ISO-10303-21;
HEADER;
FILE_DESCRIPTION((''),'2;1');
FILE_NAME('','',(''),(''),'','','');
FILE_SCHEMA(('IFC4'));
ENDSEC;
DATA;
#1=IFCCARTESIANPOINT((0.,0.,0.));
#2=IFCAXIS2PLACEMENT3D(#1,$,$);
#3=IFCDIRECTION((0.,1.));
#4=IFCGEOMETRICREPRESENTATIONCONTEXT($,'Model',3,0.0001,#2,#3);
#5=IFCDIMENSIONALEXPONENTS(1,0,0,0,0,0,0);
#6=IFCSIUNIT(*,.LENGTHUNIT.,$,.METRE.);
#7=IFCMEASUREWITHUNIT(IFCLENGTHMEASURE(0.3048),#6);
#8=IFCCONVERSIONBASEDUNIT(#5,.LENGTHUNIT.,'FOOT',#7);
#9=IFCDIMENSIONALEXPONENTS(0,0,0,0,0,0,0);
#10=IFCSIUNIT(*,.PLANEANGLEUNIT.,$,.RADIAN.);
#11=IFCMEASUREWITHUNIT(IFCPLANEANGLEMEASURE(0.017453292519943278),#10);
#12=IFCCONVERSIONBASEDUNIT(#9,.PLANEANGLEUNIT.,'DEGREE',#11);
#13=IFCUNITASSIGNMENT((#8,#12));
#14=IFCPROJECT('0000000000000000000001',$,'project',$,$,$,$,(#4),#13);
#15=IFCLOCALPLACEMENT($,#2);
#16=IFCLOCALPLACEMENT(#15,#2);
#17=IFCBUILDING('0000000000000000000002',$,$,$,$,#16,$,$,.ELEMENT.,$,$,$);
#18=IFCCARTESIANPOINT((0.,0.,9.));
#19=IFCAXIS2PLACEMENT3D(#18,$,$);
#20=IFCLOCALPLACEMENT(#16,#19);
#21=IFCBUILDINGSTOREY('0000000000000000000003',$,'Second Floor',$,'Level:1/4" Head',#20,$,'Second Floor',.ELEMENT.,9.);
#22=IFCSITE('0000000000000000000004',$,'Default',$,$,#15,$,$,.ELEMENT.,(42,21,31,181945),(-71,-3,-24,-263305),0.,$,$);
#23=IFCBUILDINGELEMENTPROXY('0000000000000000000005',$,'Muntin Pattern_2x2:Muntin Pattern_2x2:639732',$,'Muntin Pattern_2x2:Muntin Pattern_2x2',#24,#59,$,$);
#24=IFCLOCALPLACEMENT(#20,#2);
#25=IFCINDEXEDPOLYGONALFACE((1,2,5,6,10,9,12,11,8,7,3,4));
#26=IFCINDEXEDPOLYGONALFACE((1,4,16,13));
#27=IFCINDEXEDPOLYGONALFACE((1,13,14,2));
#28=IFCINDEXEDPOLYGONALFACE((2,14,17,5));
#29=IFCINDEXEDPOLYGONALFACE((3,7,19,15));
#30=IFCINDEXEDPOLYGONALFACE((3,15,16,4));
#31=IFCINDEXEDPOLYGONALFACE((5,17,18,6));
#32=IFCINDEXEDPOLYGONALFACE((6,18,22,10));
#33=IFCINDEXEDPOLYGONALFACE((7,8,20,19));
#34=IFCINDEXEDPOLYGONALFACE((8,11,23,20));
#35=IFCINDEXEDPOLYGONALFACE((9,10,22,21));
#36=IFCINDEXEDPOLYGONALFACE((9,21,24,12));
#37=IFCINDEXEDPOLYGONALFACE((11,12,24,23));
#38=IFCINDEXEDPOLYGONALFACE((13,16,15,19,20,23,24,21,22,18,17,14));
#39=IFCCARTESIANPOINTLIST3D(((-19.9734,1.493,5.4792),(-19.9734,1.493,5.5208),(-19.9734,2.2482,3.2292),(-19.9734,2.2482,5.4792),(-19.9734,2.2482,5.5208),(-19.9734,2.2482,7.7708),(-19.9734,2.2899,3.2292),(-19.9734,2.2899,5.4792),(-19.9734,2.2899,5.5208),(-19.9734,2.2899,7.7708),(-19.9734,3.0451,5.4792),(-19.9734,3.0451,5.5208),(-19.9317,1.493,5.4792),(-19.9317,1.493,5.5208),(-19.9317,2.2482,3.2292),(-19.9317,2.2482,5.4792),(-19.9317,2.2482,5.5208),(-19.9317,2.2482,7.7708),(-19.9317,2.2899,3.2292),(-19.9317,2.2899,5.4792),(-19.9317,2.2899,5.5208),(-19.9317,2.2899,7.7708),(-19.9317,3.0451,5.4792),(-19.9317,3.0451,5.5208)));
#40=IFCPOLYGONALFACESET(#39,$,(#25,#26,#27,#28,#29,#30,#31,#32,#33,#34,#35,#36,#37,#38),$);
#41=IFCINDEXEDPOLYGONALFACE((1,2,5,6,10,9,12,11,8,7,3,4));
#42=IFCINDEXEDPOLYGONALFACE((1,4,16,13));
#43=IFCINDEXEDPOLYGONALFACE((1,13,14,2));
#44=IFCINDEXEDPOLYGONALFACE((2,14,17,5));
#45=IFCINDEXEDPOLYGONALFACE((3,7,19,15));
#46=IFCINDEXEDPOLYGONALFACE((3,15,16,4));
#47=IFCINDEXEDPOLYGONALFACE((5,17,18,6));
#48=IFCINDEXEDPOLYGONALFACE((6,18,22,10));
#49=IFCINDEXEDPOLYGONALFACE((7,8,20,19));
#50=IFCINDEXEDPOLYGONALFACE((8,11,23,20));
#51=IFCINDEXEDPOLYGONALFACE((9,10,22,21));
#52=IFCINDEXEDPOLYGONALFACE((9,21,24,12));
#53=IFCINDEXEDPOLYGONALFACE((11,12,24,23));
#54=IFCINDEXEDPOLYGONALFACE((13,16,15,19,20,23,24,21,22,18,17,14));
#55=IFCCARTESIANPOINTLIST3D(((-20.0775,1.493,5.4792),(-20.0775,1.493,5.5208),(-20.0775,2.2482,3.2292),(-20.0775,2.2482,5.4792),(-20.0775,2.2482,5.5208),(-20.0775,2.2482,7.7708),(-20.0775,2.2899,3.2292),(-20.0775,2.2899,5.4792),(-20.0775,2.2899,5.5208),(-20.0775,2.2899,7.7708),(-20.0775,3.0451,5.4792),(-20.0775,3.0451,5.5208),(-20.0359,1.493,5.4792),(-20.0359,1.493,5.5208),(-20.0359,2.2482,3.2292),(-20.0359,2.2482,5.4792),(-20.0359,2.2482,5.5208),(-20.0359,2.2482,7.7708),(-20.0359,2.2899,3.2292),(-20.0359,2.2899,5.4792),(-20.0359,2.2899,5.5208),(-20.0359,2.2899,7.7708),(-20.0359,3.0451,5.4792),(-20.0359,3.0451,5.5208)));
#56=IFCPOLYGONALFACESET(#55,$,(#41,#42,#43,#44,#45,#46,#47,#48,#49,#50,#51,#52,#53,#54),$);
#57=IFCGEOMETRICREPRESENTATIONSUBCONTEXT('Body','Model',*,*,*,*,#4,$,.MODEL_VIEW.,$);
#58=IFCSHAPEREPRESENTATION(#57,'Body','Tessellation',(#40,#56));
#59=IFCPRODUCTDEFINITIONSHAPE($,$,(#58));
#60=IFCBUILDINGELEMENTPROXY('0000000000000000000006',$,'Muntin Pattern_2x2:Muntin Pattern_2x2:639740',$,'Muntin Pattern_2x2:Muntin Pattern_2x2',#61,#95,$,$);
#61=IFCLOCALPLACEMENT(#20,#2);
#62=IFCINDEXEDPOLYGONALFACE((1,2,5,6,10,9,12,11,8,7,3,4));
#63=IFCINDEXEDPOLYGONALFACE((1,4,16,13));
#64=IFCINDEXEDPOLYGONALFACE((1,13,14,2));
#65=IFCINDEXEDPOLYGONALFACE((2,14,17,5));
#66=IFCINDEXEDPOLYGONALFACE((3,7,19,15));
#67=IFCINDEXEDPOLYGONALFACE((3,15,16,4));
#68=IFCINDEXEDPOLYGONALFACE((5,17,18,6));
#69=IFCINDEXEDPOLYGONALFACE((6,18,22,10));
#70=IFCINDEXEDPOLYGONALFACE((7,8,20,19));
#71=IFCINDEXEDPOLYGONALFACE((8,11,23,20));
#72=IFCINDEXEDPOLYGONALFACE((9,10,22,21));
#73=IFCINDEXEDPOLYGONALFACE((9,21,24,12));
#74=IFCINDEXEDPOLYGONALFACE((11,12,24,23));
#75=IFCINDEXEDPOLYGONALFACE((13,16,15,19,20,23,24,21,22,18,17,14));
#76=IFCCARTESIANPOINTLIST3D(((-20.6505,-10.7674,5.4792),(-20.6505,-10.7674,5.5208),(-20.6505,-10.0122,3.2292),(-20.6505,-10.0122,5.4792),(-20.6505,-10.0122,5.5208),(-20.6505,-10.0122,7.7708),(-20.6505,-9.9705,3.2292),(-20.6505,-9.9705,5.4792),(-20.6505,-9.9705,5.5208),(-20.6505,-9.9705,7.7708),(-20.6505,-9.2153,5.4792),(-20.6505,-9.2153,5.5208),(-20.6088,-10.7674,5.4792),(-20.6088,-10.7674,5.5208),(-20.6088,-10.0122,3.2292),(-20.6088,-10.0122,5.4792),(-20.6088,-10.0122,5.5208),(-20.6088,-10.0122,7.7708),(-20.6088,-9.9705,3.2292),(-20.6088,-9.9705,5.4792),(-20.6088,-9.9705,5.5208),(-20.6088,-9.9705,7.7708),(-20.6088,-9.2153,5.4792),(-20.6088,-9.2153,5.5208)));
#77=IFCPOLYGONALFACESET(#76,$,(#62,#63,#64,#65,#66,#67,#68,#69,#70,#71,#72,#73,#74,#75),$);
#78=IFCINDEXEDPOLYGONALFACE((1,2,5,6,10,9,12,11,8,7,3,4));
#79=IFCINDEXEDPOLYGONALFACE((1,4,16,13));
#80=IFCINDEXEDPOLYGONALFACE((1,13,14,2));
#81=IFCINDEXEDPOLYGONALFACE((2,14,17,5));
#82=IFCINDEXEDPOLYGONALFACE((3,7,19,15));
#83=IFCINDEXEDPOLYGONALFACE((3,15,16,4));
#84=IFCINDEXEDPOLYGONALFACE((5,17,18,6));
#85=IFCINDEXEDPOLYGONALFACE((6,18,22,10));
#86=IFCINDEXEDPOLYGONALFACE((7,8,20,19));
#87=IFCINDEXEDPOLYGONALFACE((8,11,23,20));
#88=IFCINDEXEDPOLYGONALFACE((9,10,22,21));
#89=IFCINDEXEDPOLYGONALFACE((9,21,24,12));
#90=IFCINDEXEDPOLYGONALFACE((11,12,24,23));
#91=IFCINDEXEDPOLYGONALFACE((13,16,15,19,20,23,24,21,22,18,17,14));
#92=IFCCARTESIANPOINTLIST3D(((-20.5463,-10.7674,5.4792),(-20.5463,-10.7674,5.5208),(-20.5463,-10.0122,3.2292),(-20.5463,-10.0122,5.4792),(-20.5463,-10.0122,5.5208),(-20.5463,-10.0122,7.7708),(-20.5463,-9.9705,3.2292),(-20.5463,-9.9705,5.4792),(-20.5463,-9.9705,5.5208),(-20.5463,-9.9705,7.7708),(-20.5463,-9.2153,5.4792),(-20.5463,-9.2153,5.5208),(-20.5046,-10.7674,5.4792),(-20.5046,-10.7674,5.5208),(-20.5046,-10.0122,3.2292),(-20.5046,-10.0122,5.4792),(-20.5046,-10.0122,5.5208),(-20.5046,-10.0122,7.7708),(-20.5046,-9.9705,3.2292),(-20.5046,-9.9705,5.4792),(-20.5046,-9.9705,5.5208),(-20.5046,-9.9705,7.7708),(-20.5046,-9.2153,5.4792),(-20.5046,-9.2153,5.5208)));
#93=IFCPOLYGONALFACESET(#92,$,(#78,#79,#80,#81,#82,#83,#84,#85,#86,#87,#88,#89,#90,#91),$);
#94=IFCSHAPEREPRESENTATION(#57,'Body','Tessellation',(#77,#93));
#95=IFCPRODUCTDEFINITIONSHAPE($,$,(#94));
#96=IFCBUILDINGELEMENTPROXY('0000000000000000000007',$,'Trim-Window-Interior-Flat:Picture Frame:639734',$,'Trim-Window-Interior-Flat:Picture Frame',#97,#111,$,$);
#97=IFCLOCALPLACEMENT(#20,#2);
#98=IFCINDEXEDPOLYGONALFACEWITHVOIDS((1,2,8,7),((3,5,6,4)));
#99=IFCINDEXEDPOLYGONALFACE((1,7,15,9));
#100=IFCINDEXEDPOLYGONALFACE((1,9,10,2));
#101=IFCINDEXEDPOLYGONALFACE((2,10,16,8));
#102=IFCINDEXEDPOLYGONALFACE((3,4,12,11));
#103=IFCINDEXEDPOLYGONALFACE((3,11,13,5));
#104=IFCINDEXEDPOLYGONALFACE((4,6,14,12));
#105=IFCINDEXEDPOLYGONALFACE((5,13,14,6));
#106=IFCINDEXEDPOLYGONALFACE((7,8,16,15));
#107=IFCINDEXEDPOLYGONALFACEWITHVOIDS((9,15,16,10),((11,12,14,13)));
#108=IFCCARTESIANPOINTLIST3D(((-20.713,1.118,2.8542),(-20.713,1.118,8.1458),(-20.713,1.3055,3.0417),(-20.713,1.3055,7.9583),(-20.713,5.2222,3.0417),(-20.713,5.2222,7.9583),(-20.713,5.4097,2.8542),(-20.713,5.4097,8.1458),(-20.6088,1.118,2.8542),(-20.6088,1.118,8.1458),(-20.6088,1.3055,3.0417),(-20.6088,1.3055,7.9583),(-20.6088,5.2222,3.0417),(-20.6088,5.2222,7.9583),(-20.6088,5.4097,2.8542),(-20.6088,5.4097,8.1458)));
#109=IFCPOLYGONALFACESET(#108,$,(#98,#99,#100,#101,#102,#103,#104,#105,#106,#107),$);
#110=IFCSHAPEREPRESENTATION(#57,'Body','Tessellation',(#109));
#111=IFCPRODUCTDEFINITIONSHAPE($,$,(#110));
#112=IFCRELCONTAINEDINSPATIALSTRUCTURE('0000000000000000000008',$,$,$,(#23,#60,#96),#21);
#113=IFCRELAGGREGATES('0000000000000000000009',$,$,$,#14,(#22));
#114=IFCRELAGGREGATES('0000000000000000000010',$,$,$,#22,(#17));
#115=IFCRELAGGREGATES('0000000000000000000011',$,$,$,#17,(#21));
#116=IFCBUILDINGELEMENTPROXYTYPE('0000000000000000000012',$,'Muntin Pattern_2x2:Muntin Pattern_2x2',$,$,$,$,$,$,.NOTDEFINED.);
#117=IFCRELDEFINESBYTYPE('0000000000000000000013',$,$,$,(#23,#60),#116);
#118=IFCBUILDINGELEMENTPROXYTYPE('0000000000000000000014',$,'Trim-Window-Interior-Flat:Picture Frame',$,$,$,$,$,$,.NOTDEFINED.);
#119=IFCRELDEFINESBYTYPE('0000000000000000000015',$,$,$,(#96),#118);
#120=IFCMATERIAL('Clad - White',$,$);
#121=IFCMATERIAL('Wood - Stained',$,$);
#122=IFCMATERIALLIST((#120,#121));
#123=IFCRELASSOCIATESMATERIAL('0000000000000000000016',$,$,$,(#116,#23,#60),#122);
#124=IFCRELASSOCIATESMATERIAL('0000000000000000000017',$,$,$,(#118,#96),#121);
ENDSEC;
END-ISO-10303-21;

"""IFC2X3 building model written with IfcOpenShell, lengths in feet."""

from ifc_helpers import new_model, entity, si_unit, converted_unit, direction, frame, origin, place, context, subcontext, project, spatial, polyline, outline, extrude, source, transform, mapped, material, material_list, type_object, type_shapes, element, save


model = new_model("IFC2X3")

# Units and contexts
model_context = context("Model", 3, precision=0.0001, world=origin(), true_north=direction((0.0, 1.0)))
body_context = subcontext(model_context, "Body", "Model", "MODEL_VIEW")
ifc_project = project(units=[converted_unit("LENGTHUNIT", "FOOT", entity("IfcLengthMeasure", 0.3048), si_unit("LENGTHUNIT", "METRE"), dimensions=[1, 0, 0, 0, 0, 0, 0]), converted_unit("PLANEANGLEUNIT", "DEGREE", entity("IfcPlaneAngleMeasure", 0.017453292519943278), si_unit("PLANEANGLEUNIT", "RADIAN"), dimensions=[0, 0, 0, 0, 0, 0, 0])], contexts=[model_context])

# Site, building, storey
site_placement = place(None, origin())
site = spatial("IfcSite", under=ifc_project, at=site_placement, Name="Default", CompositionType="ELEMENT", RefLatitude=(42, 21, 31, 181945), RefLongitude=(-71, -3, -24, -263305), RefElevation=0.0)
building_placement = place(site_placement, origin())
building = spatial("IfcBuilding", under=site, at=building_placement, CompositionType="ELEMENT")
storey_placement = place(building_placement, frame((0.0, 0.0, 9.0)))
storey = spatial("IfcBuildingStorey", under=building, at=storey_placement, Name="Second Floor", ObjectType="Level:1/4\" Head", LongName="Second Floor", CompositionType="ELEMENT", Elevation=9.0)

# Building element proxies
ifc_material_1 = material(Name="Clad - White")
ifc_material_2 = material(Name="Wood - Stained")
ifc_material_list_1 = material_list([ifc_material_1, ifc_material_2])
building_element_proxy_type_1 = type_object("IfcBuildingElementProxyType", Name="Muntin Pattern_2x2:Muntin Pattern_2x2", PredefinedType="NOTDEFINED", material=ifc_material_list_1)
shared_shape_1 = source(origin(), body_context, "Body", "SweptSolid", [
    extrude(outline(polyline([(0.0208, -0.0208), (2.2708, -0.0208), (2.2708, 0.0208), (0.0208, 0.0208), (0.0208, 0.776), (-0.0208, 0.776), (-0.0208, 0.0208), (-2.2708, 0.0208), (-2.2708, -0.0208), (-0.0208, -0.0208), (-0.0208, -0.776), (0.0208, -0.776), (0.0208, -0.0208)])), frame((0.0, -0.0729, 2.2708), z_axis=(0.0, 1.0, 0.0), x_axis=(0.0, 0.0, 1.0)), (0.0, 0.0, 1.0), 0.0417),
    extrude(outline(polyline([(0.0208, -0.0208), (2.2708, -0.0208), (2.2708, 0.0208), (0.0208, 0.0208), (0.0208, 0.776), (-0.0208, 0.776), (-0.0208, 0.0208), (-2.2708, 0.0208), (-2.2708, -0.0208), (-0.0208, -0.0208), (-0.0208, -0.776), (0.0208, -0.776), (0.0208, -0.0208)])), frame((0.0, 0.0313, 2.2708), z_axis=(0.0, 1.0, 0.0), x_axis=(0.0, 0.0, 1.0)), (0.0, 0.0, 1.0), 0.0417),
])
type_shapes(building_element_proxy_type_1, [shared_shape_1])
for number, where, z_axis, x_axis, name in (
    (1, (-20.0046, 2.2691, 3.2292), (0.0, 0.0, 1.0), (0.0, 1.0, 0.0), "Muntin Pattern_2x2:Muntin Pattern_2x2:639732"),
    (2, (-20.5775, -9.9913, 3.2292), (0.0, 0.0, 1.0), (0.0, -1.0, 0.0), "Muntin Pattern_2x2:Muntin Pattern_2x2:639740"),
):
    element("IfcBuildingElementProxy", number, at=place(storey_placement, frame(where, z_axis=z_axis, x_axis=x_axis)), inside=storey, type_object=building_element_proxy_type_1, material=ifc_material_list_1, Name=name, ObjectType="Muntin Pattern_2x2:Muntin Pattern_2x2", context=body_context, shape_type="MappedRepresentation", body=[
        mapped(shared_shape_1, transform((0.0, 0.0, 0.0), scale=1.0)),
    ])
building_element_proxy_type_2 = type_object("IfcBuildingElementProxyType", Name="Trim-Window-Interior-Flat:Picture Frame", PredefinedType="NOTDEFINED", material=ifc_material_2)
shared_shape_2 = source(origin(), body_context, "Body", "SweptSolid", [
    extrude(outline(polyline([(-2.1458, -2.6458), (2.1458, -2.6458), (2.1458, 2.6458), (-2.1458, 2.6458), (-2.1458, -2.6458)]), holes=[polyline([(-1.9583, -2.4583), (-1.9583, 2.4583), (1.9583, 2.4583), (1.9583, -2.4583), (-1.9583, -2.4583)])]), frame((0.0, -2.5, 0.0), z_axis=(0.0, 0.0, 1.0), x_axis=(-1.0, 0.0, 0.0)), (0.0, 0.0, 1.0), 0.1042),
])
type_shapes(building_element_proxy_type_2, [shared_shape_2])
proxy_1_placement = place(storey_placement, frame((-20.6088, 3.2639, 8.0), z_axis=(-1.0, 0.0, 0.0), x_axis=(0.0, -1.0, 0.0)))
element("IfcBuildingElementProxy", 3, at=proxy_1_placement, inside=storey, type_object=building_element_proxy_type_2, material=ifc_material_2, Name="Trim-Window-Interior-Flat:Picture Frame:639734", ObjectType="Trim-Window-Interior-Flat:Picture Frame", context=body_context, shape_type="MappedRepresentation", body=[
    mapped(shared_shape_2, transform((0.0, 0.0, 0.0), scale=1.0)),
])

save(model, "model.ifc")
